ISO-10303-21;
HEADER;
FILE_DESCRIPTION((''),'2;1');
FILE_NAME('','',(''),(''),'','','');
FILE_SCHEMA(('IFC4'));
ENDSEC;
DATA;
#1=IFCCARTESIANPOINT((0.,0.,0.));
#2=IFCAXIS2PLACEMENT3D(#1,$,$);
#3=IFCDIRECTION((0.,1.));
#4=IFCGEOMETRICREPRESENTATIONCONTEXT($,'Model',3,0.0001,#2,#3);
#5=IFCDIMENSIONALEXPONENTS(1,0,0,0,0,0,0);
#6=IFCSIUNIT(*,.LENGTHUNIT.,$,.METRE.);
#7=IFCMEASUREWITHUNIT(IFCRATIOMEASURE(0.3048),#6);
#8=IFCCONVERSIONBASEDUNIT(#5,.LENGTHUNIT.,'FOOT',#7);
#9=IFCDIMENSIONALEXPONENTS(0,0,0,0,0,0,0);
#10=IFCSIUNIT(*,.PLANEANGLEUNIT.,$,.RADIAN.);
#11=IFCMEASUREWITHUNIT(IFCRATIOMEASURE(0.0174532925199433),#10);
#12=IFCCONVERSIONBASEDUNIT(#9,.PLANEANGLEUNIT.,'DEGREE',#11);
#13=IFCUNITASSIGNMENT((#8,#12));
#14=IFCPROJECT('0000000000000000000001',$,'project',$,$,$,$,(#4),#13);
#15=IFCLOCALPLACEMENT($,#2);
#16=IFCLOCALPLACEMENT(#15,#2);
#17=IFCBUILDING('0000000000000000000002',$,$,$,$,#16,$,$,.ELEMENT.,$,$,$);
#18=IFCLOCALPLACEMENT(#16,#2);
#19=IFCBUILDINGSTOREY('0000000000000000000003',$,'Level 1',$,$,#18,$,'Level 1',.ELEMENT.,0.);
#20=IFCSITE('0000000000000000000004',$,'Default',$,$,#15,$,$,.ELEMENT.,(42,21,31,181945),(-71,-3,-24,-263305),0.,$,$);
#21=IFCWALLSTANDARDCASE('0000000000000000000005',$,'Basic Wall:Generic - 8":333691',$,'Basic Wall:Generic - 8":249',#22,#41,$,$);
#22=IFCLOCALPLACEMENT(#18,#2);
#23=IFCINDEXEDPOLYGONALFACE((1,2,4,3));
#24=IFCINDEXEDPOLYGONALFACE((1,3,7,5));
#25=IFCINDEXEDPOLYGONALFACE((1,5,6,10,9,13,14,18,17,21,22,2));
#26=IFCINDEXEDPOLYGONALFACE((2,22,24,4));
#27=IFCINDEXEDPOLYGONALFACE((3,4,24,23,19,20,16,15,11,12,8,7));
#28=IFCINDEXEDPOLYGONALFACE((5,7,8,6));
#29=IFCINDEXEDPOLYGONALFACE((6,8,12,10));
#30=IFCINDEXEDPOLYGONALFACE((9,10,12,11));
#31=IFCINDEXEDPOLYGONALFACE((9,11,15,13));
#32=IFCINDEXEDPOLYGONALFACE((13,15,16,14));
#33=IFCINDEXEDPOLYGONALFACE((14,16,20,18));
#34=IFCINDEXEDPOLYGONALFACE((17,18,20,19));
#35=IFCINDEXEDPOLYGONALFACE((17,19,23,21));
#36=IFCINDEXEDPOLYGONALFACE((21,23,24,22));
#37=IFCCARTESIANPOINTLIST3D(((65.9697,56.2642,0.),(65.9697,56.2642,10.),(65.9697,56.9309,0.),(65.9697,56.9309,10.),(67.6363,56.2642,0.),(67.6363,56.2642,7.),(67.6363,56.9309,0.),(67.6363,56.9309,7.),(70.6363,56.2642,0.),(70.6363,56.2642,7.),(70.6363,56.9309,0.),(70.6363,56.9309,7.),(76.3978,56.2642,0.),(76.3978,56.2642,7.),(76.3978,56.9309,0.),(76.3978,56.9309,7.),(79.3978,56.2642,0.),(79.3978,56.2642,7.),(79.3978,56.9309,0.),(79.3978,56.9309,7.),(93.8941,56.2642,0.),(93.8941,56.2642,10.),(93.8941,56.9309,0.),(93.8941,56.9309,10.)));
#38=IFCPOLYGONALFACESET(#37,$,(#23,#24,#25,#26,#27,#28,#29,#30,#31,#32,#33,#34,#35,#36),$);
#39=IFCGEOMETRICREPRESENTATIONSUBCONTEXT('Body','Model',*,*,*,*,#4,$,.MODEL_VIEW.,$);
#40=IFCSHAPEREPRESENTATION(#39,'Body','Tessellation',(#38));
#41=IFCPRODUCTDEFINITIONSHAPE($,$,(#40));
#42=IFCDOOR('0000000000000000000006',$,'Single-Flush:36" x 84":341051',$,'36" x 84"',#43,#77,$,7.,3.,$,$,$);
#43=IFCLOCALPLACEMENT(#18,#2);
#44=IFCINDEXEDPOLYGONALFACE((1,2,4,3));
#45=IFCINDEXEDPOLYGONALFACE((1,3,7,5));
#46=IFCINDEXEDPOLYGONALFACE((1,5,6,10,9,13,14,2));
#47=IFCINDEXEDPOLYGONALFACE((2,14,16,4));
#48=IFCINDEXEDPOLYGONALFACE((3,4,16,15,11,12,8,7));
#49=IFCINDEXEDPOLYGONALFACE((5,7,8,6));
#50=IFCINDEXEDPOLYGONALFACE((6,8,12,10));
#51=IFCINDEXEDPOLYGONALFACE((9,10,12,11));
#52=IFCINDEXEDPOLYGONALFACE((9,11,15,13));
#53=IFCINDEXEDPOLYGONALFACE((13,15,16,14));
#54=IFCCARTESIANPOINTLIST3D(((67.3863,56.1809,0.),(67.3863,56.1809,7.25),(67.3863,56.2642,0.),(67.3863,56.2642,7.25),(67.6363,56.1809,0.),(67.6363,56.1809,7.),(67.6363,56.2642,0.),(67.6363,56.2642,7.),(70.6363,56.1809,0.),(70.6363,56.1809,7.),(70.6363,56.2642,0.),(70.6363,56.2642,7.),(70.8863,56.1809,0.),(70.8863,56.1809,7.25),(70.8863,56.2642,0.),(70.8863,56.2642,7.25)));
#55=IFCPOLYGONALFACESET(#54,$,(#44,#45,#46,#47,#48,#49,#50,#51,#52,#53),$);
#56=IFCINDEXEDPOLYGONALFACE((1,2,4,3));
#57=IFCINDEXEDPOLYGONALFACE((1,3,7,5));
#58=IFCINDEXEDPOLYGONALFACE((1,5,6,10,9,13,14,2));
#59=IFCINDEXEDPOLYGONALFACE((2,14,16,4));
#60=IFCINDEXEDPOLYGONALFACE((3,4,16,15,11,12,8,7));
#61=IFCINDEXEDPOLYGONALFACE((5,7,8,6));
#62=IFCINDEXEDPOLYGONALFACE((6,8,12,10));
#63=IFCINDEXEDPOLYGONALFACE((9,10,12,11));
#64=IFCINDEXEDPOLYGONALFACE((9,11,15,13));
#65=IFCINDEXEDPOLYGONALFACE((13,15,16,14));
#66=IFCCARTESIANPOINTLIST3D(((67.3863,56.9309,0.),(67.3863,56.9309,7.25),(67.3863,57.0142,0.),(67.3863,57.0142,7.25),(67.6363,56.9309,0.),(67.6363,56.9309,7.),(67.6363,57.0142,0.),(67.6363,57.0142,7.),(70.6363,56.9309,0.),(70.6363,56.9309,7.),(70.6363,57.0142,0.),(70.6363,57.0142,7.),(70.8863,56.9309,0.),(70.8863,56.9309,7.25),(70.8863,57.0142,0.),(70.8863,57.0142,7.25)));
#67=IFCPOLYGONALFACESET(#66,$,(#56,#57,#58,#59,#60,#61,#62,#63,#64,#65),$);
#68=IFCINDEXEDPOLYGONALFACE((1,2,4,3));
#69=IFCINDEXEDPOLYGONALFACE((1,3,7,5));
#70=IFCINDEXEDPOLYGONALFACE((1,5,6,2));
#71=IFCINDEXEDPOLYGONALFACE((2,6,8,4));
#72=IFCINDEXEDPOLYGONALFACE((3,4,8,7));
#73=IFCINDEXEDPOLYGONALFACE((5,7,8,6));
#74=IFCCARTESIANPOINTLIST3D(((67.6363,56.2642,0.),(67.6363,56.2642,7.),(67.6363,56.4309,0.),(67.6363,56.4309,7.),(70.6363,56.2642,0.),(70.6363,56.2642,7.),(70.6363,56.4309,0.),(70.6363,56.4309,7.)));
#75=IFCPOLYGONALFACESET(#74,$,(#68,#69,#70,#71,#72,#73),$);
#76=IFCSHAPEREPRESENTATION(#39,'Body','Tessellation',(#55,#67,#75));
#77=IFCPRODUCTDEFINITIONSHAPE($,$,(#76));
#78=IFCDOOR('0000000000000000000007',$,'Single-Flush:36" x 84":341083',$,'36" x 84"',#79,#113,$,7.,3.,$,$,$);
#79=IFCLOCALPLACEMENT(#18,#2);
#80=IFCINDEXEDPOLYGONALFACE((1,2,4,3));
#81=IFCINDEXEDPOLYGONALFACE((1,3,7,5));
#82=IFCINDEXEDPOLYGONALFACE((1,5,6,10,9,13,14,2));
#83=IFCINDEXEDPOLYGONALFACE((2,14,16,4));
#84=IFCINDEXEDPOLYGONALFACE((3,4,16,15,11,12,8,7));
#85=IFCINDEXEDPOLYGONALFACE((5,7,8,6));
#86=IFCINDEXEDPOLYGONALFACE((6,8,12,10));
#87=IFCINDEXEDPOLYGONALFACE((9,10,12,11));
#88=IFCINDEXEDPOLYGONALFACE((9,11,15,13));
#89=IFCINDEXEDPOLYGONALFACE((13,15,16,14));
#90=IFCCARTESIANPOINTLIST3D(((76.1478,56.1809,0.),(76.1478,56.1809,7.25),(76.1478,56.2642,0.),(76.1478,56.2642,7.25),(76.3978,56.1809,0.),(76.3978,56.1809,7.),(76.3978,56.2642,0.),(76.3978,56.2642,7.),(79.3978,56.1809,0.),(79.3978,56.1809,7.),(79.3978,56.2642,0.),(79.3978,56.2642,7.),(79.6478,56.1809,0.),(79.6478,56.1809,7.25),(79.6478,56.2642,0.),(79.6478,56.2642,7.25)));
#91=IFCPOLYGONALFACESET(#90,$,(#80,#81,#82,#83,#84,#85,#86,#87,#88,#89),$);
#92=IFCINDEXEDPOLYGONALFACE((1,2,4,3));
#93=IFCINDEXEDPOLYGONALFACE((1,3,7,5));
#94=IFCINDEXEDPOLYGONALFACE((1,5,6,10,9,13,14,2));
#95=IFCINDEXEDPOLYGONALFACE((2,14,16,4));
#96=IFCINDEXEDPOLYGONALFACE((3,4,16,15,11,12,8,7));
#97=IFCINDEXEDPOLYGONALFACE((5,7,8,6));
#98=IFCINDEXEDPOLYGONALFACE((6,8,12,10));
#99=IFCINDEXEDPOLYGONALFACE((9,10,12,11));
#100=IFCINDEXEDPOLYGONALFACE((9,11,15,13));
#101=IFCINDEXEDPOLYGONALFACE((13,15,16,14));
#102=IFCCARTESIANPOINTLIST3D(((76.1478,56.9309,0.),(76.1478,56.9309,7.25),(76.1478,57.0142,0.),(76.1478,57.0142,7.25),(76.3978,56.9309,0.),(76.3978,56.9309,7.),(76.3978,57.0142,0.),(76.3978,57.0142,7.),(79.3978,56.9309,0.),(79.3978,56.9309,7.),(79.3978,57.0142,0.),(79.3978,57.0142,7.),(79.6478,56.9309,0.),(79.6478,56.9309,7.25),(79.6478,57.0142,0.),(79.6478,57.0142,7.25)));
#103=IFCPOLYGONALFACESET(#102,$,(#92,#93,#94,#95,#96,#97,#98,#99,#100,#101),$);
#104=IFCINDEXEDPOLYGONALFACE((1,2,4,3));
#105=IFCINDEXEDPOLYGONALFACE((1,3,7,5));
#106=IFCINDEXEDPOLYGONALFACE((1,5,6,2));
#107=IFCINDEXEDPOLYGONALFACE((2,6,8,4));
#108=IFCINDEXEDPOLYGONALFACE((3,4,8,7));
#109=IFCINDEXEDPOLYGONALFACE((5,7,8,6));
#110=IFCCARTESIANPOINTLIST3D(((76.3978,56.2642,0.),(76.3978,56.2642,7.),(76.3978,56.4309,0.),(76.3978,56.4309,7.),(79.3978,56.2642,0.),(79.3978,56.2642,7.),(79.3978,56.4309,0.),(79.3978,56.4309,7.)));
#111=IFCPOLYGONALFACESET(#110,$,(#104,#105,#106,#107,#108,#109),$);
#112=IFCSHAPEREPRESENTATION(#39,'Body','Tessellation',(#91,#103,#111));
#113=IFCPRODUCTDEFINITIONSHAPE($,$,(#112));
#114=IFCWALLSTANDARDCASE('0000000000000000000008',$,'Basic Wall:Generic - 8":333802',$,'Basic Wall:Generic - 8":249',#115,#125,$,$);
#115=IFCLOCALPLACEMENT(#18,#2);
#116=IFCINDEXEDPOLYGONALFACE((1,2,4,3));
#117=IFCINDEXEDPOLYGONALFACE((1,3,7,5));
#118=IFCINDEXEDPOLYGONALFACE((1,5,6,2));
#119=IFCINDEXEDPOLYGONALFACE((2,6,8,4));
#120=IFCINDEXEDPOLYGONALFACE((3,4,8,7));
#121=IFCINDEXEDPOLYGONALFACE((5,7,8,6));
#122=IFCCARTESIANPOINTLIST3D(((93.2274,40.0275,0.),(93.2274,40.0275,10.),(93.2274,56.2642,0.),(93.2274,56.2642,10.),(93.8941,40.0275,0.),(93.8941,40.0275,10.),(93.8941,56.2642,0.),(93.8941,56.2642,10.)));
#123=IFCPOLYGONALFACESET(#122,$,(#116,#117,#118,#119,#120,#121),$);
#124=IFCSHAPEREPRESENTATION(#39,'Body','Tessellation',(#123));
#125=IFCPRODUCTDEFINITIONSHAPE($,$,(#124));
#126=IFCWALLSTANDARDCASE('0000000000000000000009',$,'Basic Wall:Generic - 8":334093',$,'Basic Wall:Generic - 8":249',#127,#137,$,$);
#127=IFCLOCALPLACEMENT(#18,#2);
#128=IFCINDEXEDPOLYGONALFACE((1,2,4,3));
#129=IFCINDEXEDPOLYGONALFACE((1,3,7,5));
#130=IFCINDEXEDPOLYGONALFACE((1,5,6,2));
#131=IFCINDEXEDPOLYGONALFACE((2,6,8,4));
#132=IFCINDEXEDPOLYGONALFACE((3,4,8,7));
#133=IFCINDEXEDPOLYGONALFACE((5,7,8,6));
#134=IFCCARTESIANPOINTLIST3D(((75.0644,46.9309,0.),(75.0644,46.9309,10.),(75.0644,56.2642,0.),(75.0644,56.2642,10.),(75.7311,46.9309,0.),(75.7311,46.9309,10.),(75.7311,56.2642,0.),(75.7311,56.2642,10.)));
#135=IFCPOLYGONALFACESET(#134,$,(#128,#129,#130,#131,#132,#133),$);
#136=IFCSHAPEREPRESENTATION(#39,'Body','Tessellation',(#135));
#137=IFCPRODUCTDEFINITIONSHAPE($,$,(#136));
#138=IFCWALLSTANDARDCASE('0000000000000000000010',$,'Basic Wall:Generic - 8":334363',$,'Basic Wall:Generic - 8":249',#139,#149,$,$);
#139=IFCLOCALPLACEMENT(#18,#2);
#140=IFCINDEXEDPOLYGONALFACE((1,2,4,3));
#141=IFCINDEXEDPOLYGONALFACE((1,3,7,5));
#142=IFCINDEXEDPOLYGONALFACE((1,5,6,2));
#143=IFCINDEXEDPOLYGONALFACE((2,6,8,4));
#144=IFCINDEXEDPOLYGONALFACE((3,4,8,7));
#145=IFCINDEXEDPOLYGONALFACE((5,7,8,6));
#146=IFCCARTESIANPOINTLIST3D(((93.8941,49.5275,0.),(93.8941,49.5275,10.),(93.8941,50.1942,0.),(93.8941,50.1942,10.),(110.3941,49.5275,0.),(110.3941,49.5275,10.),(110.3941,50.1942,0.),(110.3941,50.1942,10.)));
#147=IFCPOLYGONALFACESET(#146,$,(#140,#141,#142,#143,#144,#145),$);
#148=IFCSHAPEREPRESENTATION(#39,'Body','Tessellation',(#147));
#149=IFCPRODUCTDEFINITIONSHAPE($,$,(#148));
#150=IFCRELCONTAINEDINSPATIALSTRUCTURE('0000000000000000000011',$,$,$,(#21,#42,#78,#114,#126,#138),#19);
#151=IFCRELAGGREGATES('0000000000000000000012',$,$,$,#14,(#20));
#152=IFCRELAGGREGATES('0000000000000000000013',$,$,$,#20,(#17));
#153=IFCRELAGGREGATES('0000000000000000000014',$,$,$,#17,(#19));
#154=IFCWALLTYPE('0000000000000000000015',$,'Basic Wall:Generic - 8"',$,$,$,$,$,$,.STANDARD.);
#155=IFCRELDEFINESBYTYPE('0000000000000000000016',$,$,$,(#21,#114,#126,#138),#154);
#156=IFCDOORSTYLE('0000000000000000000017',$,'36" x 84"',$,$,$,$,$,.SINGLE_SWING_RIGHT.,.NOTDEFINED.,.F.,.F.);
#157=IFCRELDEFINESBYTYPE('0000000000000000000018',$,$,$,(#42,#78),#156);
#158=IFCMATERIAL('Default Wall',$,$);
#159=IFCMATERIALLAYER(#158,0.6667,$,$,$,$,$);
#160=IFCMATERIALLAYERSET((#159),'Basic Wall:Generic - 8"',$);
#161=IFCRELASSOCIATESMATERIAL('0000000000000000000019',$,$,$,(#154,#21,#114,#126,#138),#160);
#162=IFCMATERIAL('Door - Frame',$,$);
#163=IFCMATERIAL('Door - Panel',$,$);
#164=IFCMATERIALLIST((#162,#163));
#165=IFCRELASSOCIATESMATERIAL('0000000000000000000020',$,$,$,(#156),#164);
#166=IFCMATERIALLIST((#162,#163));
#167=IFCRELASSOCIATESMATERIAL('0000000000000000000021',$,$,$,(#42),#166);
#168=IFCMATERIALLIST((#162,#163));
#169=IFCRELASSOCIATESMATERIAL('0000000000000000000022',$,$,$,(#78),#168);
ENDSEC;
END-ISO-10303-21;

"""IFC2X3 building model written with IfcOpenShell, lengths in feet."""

from ifc_helpers import new_model, entity, si_unit, converted_unit, direction, frame, frame_2d, origin, place, context, subcontext, project, spatial, polyline, rectangle, outline, extrude, source, transform, mapped, material, material_list, layer, layer_set, layer_usage, type_object, type_shapes, element, fill, save


model = new_model("IFC2X3")

# Units and contexts
model_context = context("Model", 3, precision=0.0001, world=origin(), true_north=direction((0.0, 1.0)))
body_context = subcontext(model_context, "Body", "Model", "MODEL_VIEW")
ifc_project = project(units=[converted_unit("LENGTHUNIT", "FOOT", entity("IfcRatioMeasure", 0.3048), si_unit("LENGTHUNIT", "METRE"), dimensions=[1, 0, 0, 0, 0, 0, 0]), converted_unit("PLANEANGLEUNIT", "DEGREE", entity("IfcRatioMeasure", 0.0174532925199433), si_unit("PLANEANGLEUNIT", "RADIAN"), dimensions=[0, 0, 0, 0, 0, 0, 0])], contexts=[model_context])

# Site, building, storey
site_placement = place(None, origin())
site = spatial("IfcSite", under=ifc_project, at=site_placement, Name="Default", CompositionType="ELEMENT", RefLatitude=(42, 21, 31, 181945), RefLongitude=(-71, -3, -24, -263305), RefElevation=0.0)
building_placement = place(site_placement, origin())
building = spatial("IfcBuilding", under=site, at=building_placement, CompositionType="ELEMENT")
storey_placement = place(building_placement, origin())
storey = spatial("IfcBuildingStorey", under=building, at=storey_placement, Name="Level 1", LongName="Level 1", CompositionType="ELEMENT", Elevation=0.0)

# Shared definitions
ifc_material_1 = material(Name="Default Wall")
ifc_layer = layer(ifc_material_1, 0.6667)
ifc_layer_set = layer_set([ifc_layer], Name="Basic Wall:Generic - 8\"")
wall_type = type_object("IfcWallType", Name="Basic Wall:Generic - 8\"", PredefinedType="STANDARD", material=ifc_layer_set)

# Wall, openings, doors
ifc_layer_usage_1 = layer_usage(ifc_layer_set, "AXIS2", "NEGATIVE", 0.3333)
wall_1_placement = place(storey_placement, frame((93.8941, 56.5976, 0.0), z_axis=(0.0, 0.0, 1.0), x_axis=(-1.0, 0.0, 0.0)))
wall_1 = element("IfcWallStandardCase", 1, at=wall_1_placement, inside=storey, type_object=wall_type, material=ifc_layer_usage_1, Name="Basic Wall:Generic - 8\":333691", ObjectType="Basic Wall:Generic - 8\":249", context=body_context, shape_type="SweptSolid", body=[
    extrude(rectangle(XDim=27.9244, YDim=0.6667, at=frame_2d((13.9622, 0.0), x_axis=(-1.0, 0.0))), origin(), (0.0, 0.0, 1.0), 10.0),
])
opening_1_placement = place(wall_1_placement, frame((23.2578, -0.3333, 0.0)))
opening_1 = element("IfcOpeningElement", 2, at=opening_1_placement, cuts=wall_1, ObjectType="Opening", context=body_context, shape_type="SweptSolid", body=[
    extrude(rectangle(XDim=3.0, YDim=7.0, at=frame_2d((3.5, 1.5), x_axis=(0.0, 1.0))), frame((0.0, 0.0, 0.0), z_axis=(0.0, 1.0, 0.0), x_axis=(0.0, 0.0, 1.0)), (0.0, 0.0, 1.0), 0.6667),
])
opening_2_placement = place(wall_1_placement, frame((14.4963, -0.3333, 0.0)))
opening_2 = element("IfcOpeningElement", 3, at=opening_2_placement, cuts=wall_1, ObjectType="Opening", context=body_context, shape_type="SweptSolid", body=[
    extrude(rectangle(XDim=3.0, YDim=7.0, at=frame_2d((3.5, 1.5), x_axis=(0.0, 1.0))), frame((0.0, 0.0, 0.0), z_axis=(0.0, 1.0, 0.0), x_axis=(0.0, 0.0, 1.0)), (0.0, 0.0, 1.0), 0.6667),
])
ifc_material_2 = material(Name="Door - Frame")
ifc_material_3 = material(Name="Door - Panel")
ifc_material_list_1 = material_list([ifc_material_2, ifc_material_3])
ifc_material_list_2 = material_list([ifc_material_2, ifc_material_3])
door_style_1 = type_object("IfcDoorStyle", Name="36\" x 84\"", ConstructionType="NOTDEFINED", OperationType="SINGLE_SWING_RIGHT", ParameterTakesPrecedence=False, Sizeable=False, material=ifc_material_list_2)
shared_shape_1 = source(origin(), body_context, "Body", "SweptSolid", [
    extrude(outline(polyline([(-1.75, -3.6875), (1.75, -3.6875), (1.75, 3.5625), (1.5, 3.5625), (1.5, -3.4375), (-1.5, -3.4375), (-1.5, 3.5625), (-1.75, 3.5625), (-1.75, -3.6875)])), frame((1.5, 0.6667, 3.5625), z_axis=(0.0, 1.0, 0.0), x_axis=(1.0, 0.0, 0.0)), (0.0, 0.0, 1.0), 0.0833),
    extrude(outline(polyline([(-3.6875, -1.75), (3.5625, -1.75), (3.5625, -1.5), (-3.4375, -1.5), (-3.4375, 1.5), (3.5625, 1.5), (3.5625, 1.75), (-3.6875, 1.75), (-3.6875, -1.75)])), frame((1.5, -0.0833, 3.5625), z_axis=(0.0, 1.0, 0.0), x_axis=(0.0, 0.0, -1.0)), (0.0, 0.0, 1.0), 0.0833),
    extrude(rectangle(XDim=0.1667, YDim=3.0, at=frame_2d((0.0, 0.0), x_axis=(1.0, 0.0))), frame((1.5, 0.5833, 0.0), z_axis=(0.0, 0.0, 1.0), x_axis=(0.0, 1.0, 0.0)), (0.0, 0.0, 1.0), 7.0),
])
type_shapes(door_style_1, [shared_shape_1])
door_1_placement = place(opening_1_placement, origin())
door_1 = element("IfcDoor", 4, at=door_1_placement, inside=storey, type_object=door_style_1, material=ifc_material_list_1, Name="Single-Flush:36\" x 84\":341051", ObjectType="36\" x 84\"", OverallHeight=7.0, OverallWidth=3.0, context=body_context, shape_type="MappedRepresentation", body=[
    mapped(shared_shape_1, transform((0.0, 0.0, 0.0), scale=1.0)),
])
fill(opening_1, door_1)
ifc_material_list_3 = material_list([ifc_material_2, ifc_material_3])
door_2_placement = place(opening_2_placement, origin())
door_2 = element("IfcDoor", 5, at=door_2_placement, inside=storey, type_object=door_style_1, material=ifc_material_list_3, Name="Single-Flush:36\" x 84\":341083", ObjectType="36\" x 84\"", OverallHeight=7.0, OverallWidth=3.0, context=body_context, shape_type="MappedRepresentation", body=[
    mapped(shared_shape_1, transform((0.0, 0.0, 0.0), scale=1.0)),
])
fill(opening_2, door_2)

# Walls
ifc_layer_usage_2 = layer_usage(ifc_layer_set, "AXIS2", "NEGATIVE", 0.3333)
wall_2_placement = place(storey_placement, frame((93.5608, 56.2642, 0.0), z_axis=(0.0, 0.0, 1.0), x_axis=(0.0, -1.0, 0.0)))
element("IfcWallStandardCase", 6, at=wall_2_placement, inside=storey, type_object=wall_type, material=ifc_layer_usage_2, Name="Basic Wall:Generic - 8\":333802", ObjectType="Basic Wall:Generic - 8\":249", context=body_context, shape_type="SweptSolid", body=[
    extrude(rectangle(XDim=16.2367, YDim=0.6667, at=frame_2d((8.1184, 0.0), x_axis=(-1.0, 0.0))), origin(), (0.0, 0.0, 1.0), 10.0),
])
ifc_layer_usage_3 = layer_usage(ifc_layer_set, "AXIS2", "NEGATIVE", 0.3333)
wall_3_placement = place(storey_placement, frame((75.3978, 56.2642, 0.0), z_axis=(0.0, 0.0, 1.0), x_axis=(0.0, -1.0, 0.0)))
element("IfcWallStandardCase", 7, at=wall_3_placement, inside=storey, type_object=wall_type, material=ifc_layer_usage_3, Name="Basic Wall:Generic - 8\":334093", ObjectType="Basic Wall:Generic - 8\":249", context=body_context, shape_type="SweptSolid", body=[
    extrude(rectangle(XDim=9.3333, YDim=0.6667, at=frame_2d((4.6667, 0.0), x_axis=(-1.0, 0.0))), origin(), (0.0, 0.0, 1.0), 10.0),
])
ifc_layer_usage_4 = layer_usage(ifc_layer_set, "AXIS2", "NEGATIVE", 0.3333)
wall_4_placement = place(storey_placement, frame((93.8941, 49.8609, 0.0)))
element("IfcWallStandardCase", 8, at=wall_4_placement, inside=storey, type_object=wall_type, material=ifc_layer_usage_4, Name="Basic Wall:Generic - 8\":334363", ObjectType="Basic Wall:Generic - 8\":249", context=body_context, shape_type="SweptSolid", body=[
    extrude(rectangle(XDim=16.5, YDim=0.6667, at=frame_2d((8.25, 0.0), x_axis=(-1.0, 0.0))), origin(), (0.0, 0.0, 1.0), 10.0),
])

save(model, "model.ifc")
